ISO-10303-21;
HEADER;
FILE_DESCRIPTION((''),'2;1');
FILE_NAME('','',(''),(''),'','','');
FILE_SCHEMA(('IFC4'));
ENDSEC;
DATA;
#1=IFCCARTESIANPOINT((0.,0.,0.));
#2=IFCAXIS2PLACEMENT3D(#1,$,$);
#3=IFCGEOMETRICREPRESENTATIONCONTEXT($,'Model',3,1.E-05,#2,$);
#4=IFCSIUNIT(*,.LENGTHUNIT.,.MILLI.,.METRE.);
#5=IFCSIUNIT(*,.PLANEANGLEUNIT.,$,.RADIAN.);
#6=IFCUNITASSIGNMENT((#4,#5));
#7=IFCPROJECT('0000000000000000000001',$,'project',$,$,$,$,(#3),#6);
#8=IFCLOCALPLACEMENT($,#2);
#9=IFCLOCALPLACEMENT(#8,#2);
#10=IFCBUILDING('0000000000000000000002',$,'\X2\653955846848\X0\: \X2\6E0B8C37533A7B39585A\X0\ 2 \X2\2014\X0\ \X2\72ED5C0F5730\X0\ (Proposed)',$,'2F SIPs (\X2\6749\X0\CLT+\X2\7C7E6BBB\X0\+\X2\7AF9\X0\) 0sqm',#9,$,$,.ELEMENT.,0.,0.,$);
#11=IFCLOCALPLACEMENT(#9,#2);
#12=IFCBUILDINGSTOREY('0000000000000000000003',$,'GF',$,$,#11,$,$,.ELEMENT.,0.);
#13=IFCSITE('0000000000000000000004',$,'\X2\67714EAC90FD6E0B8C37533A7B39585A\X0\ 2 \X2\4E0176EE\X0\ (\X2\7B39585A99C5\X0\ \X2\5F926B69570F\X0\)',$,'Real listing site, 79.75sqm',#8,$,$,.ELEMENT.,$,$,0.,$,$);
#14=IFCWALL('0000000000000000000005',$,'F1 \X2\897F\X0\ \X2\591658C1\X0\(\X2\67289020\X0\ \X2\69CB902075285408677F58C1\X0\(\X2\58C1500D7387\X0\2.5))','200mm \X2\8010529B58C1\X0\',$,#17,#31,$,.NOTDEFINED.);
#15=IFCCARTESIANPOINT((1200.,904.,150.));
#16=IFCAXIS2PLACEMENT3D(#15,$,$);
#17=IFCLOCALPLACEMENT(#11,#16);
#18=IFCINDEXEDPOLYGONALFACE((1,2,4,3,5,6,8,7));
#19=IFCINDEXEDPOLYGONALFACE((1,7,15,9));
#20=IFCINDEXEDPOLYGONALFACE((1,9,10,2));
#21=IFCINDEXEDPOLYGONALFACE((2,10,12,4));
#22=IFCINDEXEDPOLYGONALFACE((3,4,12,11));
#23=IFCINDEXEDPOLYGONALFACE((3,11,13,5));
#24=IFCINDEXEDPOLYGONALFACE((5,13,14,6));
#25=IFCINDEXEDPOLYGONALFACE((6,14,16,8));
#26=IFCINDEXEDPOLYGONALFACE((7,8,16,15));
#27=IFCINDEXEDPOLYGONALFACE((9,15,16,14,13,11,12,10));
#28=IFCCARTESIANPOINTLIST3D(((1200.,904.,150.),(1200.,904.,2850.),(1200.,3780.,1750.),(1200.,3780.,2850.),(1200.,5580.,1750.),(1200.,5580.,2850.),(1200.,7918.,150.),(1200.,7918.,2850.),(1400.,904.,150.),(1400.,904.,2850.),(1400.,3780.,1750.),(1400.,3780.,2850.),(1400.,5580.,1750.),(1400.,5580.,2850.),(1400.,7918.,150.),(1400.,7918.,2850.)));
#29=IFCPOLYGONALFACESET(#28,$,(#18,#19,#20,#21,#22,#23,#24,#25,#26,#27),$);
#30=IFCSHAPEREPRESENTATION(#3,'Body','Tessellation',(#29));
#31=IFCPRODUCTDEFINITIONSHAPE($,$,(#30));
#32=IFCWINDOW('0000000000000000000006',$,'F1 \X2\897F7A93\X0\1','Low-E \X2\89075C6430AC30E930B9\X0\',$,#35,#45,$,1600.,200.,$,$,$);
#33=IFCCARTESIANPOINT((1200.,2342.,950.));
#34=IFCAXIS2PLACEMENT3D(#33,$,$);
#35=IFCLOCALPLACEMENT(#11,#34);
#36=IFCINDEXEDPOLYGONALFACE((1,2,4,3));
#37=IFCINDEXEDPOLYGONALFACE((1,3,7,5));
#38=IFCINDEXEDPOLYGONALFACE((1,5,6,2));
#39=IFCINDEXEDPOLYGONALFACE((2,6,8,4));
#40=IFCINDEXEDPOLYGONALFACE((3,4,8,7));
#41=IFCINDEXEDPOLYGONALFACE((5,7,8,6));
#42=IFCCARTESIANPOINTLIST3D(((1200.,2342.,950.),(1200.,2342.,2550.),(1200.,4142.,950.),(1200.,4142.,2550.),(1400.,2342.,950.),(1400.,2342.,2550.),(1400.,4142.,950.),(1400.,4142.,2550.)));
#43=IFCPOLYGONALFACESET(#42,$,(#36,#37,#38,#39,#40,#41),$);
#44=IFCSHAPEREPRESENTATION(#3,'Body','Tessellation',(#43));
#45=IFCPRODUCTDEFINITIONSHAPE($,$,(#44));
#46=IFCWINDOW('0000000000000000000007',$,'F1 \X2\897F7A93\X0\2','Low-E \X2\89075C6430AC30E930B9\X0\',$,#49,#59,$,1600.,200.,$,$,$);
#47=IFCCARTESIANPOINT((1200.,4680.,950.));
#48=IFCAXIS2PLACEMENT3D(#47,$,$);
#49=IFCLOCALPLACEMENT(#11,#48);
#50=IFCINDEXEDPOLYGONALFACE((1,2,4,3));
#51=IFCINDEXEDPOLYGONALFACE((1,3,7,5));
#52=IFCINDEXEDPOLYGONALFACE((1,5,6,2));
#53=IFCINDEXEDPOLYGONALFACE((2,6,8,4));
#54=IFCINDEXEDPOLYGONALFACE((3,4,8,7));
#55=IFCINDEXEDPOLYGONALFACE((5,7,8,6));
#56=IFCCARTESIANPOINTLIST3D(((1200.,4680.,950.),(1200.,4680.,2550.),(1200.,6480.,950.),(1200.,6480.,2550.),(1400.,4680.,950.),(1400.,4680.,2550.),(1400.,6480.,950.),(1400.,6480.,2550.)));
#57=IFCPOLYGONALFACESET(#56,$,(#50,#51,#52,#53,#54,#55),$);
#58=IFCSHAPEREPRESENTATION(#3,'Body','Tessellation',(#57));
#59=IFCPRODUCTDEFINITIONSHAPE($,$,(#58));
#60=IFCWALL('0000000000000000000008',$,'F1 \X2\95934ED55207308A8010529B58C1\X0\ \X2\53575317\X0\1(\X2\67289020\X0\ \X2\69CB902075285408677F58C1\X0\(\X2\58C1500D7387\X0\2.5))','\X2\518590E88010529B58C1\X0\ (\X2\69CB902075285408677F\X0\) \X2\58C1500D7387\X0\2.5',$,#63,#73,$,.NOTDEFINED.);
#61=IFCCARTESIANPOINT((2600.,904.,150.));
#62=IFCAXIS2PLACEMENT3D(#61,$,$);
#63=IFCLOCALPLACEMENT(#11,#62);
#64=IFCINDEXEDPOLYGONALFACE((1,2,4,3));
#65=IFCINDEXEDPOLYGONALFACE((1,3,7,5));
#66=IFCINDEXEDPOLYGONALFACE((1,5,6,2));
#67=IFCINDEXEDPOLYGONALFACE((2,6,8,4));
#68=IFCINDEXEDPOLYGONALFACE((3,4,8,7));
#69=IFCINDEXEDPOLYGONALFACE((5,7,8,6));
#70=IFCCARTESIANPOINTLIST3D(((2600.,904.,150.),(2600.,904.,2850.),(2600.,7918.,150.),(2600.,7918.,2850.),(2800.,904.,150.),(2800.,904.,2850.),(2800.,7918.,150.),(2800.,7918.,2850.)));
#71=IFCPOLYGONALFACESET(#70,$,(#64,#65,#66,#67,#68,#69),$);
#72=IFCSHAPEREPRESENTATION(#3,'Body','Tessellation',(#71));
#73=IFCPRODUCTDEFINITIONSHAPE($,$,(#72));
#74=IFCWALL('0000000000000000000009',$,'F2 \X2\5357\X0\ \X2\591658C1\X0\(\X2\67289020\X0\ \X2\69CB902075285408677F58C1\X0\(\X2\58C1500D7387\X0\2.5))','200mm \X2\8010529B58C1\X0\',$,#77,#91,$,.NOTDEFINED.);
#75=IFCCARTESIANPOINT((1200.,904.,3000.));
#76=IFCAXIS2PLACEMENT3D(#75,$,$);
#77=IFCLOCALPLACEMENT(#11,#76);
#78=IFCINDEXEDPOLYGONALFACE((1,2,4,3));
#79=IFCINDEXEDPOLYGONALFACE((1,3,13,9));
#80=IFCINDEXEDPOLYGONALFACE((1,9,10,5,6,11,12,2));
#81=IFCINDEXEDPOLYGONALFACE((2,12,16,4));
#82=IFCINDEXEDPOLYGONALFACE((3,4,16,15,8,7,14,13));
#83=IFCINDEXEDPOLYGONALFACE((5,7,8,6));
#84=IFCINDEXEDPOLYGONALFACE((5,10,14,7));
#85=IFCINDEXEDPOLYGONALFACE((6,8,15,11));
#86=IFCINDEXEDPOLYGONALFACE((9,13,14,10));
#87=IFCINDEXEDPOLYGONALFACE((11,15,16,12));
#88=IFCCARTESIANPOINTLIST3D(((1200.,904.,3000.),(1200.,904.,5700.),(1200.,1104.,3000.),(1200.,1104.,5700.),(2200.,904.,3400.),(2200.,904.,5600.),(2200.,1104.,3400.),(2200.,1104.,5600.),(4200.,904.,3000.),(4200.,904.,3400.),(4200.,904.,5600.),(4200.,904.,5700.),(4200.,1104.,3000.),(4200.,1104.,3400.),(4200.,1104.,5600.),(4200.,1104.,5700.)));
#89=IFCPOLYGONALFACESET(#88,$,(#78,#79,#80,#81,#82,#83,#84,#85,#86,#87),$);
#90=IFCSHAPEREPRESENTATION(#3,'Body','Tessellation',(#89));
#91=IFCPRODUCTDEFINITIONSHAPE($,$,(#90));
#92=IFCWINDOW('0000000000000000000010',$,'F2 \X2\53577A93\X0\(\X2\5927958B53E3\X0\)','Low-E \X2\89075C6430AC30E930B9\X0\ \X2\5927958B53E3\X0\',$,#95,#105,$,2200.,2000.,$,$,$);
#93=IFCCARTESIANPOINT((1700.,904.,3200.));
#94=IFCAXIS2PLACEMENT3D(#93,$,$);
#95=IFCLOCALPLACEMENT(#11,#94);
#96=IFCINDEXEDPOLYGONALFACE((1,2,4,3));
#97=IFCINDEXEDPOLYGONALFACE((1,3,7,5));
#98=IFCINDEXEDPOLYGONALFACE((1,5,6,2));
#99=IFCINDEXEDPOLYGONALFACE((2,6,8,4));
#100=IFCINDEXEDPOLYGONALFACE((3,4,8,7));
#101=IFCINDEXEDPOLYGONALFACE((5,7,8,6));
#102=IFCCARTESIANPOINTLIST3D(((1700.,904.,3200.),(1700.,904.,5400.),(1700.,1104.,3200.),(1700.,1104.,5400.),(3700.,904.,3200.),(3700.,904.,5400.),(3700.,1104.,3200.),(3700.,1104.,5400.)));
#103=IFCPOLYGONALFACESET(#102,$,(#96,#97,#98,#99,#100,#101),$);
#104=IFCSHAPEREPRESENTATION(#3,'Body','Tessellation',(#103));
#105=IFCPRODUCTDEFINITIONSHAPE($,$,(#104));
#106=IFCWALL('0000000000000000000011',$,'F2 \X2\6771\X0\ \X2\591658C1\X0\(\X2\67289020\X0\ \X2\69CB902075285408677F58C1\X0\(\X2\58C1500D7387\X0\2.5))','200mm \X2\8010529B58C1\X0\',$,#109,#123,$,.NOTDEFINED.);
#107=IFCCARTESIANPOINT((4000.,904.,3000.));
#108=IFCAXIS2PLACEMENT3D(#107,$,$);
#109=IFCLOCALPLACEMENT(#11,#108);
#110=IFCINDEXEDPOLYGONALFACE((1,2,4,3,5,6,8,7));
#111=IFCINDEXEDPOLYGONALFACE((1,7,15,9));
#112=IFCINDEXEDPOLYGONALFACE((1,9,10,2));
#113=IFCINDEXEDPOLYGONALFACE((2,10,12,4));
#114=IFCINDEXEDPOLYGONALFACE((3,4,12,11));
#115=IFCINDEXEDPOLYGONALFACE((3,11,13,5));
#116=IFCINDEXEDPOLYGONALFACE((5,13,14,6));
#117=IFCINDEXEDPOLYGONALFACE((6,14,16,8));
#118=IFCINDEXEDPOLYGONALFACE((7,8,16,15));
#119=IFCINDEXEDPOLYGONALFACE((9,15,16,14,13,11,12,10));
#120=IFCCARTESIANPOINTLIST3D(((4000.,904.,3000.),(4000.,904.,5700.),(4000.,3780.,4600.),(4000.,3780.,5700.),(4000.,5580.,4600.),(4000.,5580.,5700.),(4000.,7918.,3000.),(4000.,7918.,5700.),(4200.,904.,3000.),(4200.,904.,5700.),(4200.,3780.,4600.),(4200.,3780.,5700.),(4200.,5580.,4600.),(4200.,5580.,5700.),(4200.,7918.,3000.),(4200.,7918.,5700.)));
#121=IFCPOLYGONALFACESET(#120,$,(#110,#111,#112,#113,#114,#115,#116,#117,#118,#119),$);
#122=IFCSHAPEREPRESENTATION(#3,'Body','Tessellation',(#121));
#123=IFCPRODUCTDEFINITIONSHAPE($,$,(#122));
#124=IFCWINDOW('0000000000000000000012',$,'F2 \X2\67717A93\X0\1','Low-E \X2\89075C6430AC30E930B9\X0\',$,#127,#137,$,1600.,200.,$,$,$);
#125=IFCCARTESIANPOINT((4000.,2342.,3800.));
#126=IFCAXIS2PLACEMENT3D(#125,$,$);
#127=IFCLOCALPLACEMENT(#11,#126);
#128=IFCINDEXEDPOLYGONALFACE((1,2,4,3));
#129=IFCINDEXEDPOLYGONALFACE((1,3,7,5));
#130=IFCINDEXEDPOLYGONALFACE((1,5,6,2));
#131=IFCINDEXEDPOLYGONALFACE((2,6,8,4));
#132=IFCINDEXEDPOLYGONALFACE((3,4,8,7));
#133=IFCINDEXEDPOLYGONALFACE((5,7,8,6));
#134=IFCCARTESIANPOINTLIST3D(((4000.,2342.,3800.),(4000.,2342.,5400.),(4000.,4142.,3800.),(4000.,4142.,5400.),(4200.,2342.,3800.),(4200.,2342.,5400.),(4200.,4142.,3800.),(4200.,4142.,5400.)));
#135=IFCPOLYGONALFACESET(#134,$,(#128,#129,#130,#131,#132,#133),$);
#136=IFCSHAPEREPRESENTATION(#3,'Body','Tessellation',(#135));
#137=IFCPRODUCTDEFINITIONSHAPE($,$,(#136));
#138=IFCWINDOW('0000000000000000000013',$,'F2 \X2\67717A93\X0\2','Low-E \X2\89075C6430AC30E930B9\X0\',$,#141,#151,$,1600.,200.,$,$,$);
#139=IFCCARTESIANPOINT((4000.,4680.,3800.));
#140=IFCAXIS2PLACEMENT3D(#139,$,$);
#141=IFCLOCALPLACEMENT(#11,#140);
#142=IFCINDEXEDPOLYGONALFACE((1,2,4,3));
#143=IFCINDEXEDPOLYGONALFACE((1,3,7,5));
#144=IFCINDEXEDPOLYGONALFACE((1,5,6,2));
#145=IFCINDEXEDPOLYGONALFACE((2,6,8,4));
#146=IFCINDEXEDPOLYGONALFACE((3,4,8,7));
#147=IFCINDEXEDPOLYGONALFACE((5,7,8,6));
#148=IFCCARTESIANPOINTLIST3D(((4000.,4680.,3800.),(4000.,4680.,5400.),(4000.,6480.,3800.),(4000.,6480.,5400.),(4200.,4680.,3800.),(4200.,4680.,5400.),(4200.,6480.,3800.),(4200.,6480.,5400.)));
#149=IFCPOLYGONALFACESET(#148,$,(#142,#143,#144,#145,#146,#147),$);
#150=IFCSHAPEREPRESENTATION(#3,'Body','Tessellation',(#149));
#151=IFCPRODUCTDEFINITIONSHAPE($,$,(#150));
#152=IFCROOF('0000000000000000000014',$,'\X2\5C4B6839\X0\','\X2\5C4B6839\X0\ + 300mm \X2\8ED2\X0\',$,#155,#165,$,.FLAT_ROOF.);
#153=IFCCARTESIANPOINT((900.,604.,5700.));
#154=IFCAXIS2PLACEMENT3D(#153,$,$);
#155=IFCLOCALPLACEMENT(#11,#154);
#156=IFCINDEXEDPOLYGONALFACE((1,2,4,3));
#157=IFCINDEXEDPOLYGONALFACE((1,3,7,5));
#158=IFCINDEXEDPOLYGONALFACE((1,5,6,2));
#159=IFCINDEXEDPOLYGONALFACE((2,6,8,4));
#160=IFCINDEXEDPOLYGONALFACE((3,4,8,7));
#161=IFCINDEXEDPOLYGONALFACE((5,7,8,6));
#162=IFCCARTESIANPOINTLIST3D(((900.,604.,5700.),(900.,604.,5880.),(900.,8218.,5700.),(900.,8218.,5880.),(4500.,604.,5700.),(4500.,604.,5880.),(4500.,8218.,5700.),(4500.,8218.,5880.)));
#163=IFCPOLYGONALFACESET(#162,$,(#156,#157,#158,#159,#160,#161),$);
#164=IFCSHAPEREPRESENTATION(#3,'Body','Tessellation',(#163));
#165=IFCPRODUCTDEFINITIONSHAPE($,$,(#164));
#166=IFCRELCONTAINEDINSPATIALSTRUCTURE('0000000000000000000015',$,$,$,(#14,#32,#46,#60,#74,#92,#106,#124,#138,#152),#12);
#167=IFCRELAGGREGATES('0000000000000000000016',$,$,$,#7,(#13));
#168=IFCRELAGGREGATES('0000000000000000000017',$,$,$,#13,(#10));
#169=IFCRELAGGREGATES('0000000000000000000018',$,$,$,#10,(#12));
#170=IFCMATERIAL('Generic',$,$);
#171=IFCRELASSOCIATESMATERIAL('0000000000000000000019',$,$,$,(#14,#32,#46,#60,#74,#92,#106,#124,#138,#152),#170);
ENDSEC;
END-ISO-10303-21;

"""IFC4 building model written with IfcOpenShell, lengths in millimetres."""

from ifc_helpers import new_model, si_unit, frame, frame_2d, origin, place, context, project, spatial, rectangle, extrude, material, element, fill, save


model = new_model("IFC4")

# Units and contexts
model_context = context("Model", 3, precision=1e-05, world=origin())
ifc_project = project(units=[si_unit("LENGTHUNIT", "METRE", prefix="MILLI"), si_unit("PLANEANGLEUNIT", "RADIAN")], contexts=[model_context])

# Site, building, storey
site_placement = place(None, origin())
site = spatial("IfcSite", under=ifc_project, at=site_placement, Name="東京都渋谷区笹塚 2 丁目 (笹塚駅 徒歩圏)", ObjectType="Real listing site, 79.75sqm", CompositionType="ELEMENT", RefElevation=0.0)
building_placement = place(site_placement, origin())
building = spatial("IfcBuilding", under=site, at=building_placement, Name="改善案: 渋谷区笹塚 2 — 狭小地 (Proposed)", ObjectType="2F SIPs (杉CLT+籾殻+竹) 0sqm", CompositionType="ELEMENT", ElevationOfRefHeight=0.0, ElevationOfTerrain=0.0)
storey_placement = place(building_placement, origin())
storey = spatial("IfcBuildingStorey", under=building, at=storey_placement, Name="GF", CompositionType="ELEMENT", Elevation=0.0)

# Shared definitions
ifc_material_1 = material(Name="Generic")

# Wall, openings, windows
wall_1_placement = place(storey_placement, frame((1200.0, 904.0, 150.0)))
wall_1 = element("IfcWall", 1, at=wall_1_placement, inside=storey, material=ifc_material_1, Name="F1 西 外壁(木造 構造用合板壁(壁倍率2.5))", Description="200mm 耐力壁", PredefinedType="NOTDEFINED", context=model_context, shape_type="SweptSolid", body=[
    extrude(rectangle(XDim=200.0, YDim=7014.0, at=frame_2d((100.0, 3507.0))), frame((1200.0, 904.0, 150.0)), (0.0, 0.0, 1.0), 2700.0),
])
opening_1_placement = place(storey_placement, frame((1200.0, 2342.0, 950.0)))
opening_1 = element("IfcOpeningElement", 2, at=opening_1_placement, cuts=wall_1, PredefinedType="NOTDEFINED", context=model_context, shape_type="SweptSolid", body=[
    extrude(rectangle(XDim=200.0, YDim=1800.0, at=frame_2d((100.0, 900.0))), frame((1200.0, 2342.0, 950.0)), (0.0, 0.0, 1.0), 1600.0),
])
opening_2_placement = place(storey_placement, frame((1200.0, 4680.0, 950.0)))
opening_2 = element("IfcOpeningElement", 3, at=opening_2_placement, cuts=wall_1, PredefinedType="NOTDEFINED", context=model_context, shape_type="SweptSolid", body=[
    extrude(rectangle(XDim=200.0, YDim=1800.0, at=frame_2d((100.0, 900.0))), frame((1200.0, 4680.0, 950.0)), (0.0, 0.0, 1.0), 1600.0),
])
window_1_placement = place(storey_placement, frame((1200.0, 2342.0, 950.0)))
window_1 = element("IfcWindow", 4, at=window_1_placement, inside=storey, material=ifc_material_1, Name="F1 西窓1", Description="Low-E 複層ガラス", OverallHeight=1600.0, OverallWidth=200.0, context=model_context, shape_type="SweptSolid", body=[
    extrude(rectangle(XDim=200.0, YDim=1800.0, at=frame_2d((100.0, 900.0))), frame((1200.0, 2342.0, 950.0)), (0.0, 0.0, 1.0), 1600.0),
])
fill(opening_1, window_1)
window_2_placement = place(storey_placement, frame((1200.0, 4680.0, 950.0)))
window_2 = element("IfcWindow", 5, at=window_2_placement, inside=storey, material=ifc_material_1, Name="F1 西窓2", Description="Low-E 複層ガラス", OverallHeight=1600.0, OverallWidth=200.0, context=model_context, shape_type="SweptSolid", body=[
    extrude(rectangle(XDim=200.0, YDim=1800.0, at=frame_2d((100.0, 900.0))), frame((1200.0, 4680.0, 950.0)), (0.0, 0.0, 1.0), 1600.0),
])
fill(opening_2, window_2)

# Wall
wall_2_placement = place(storey_placement, frame((2600.0, 904.0, 150.0)))
element("IfcWall", 6, at=wall_2_placement, inside=storey, material=ifc_material_1, Name="F1 間仕切り耐力壁 南北1(木造 構造用合板壁(壁倍率2.5))", Description="内部耐力壁 (構造用合板) 壁倍率2.5", PredefinedType="NOTDEFINED", context=model_context, shape_type="SweptSolid", body=[
    extrude(rectangle(XDim=200.0, YDim=7014.0, at=frame_2d((100.0, 3507.0))), frame((2600.0, 904.0, 150.0)), (0.0, 0.0, 1.0), 2700.0),
])

# Wall, opening, window
wall_3_placement = place(storey_placement, frame((1200.0, 904.0, 3000.0)))
wall_3 = element("IfcWall", 7, at=wall_3_placement, inside=storey, material=ifc_material_1, Name="F2 南 外壁(木造 構造用合板壁(壁倍率2.5))", Description="200mm 耐力壁", PredefinedType="NOTDEFINED", context=model_context, shape_type="SweptSolid", body=[
    extrude(rectangle(XDim=3000.0, YDim=200.0, at=frame_2d((1500.0, 100.0))), frame((1200.0, 904.0, 3000.0)), (0.0, 0.0, 1.0), 2700.0),
])
opening_3_placement = place(storey_placement, frame((1700.0, 904.0, 3200.0)))
opening_3 = element("IfcOpeningElement", 8, at=opening_3_placement, cuts=wall_3, PredefinedType="NOTDEFINED", context=model_context, shape_type="SweptSolid", body=[
    extrude(rectangle(XDim=2000.0, YDim=200.0, at=frame_2d((1000.0, 100.0))), frame((1700.0, 904.0, 3200.0)), (0.0, 0.0, 1.0), 2200.0),
])
window_3_placement = place(storey_placement, frame((1700.0, 904.0, 3200.0)))
window_3 = element("IfcWindow", 9, at=window_3_placement, inside=storey, material=ifc_material_1, Name="F2 南窓(大開口)", Description="Low-E 複層ガラス 大開口", OverallHeight=2200.0, OverallWidth=2000.0, context=model_context, shape_type="SweptSolid", body=[
    extrude(rectangle(XDim=2000.0, YDim=200.0, at=frame_2d((1000.0, 100.0))), frame((1700.0, 904.0, 3200.0)), (0.0, 0.0, 1.0), 2200.0),
])
fill(opening_3, window_3)

# Wall, openings, windows
wall_4_placement = place(storey_placement, frame((4000.0, 904.0, 3000.0)))
wall_4 = element("IfcWall", 10, at=wall_4_placement, inside=storey, material=ifc_material_1, Name="F2 東 外壁(木造 構造用合板壁(壁倍率2.5))", Description="200mm 耐力壁", PredefinedType="NOTDEFINED", context=model_context, shape_type="SweptSolid", body=[
    extrude(rectangle(XDim=200.0, YDim=7014.0, at=frame_2d((100.0, 3507.0))), frame((4000.0, 904.0, 3000.0)), (0.0, 0.0, 1.0), 2700.0),
])
opening_4_placement = place(storey_placement, frame((4000.0, 2342.0, 3800.0)))
opening_4 = element("IfcOpeningElement", 11, at=opening_4_placement, cuts=wall_4, PredefinedType="NOTDEFINED", context=model_context, shape_type="SweptSolid", body=[
    extrude(rectangle(XDim=200.0, YDim=1800.0, at=frame_2d((100.0, 900.0))), frame((4000.0, 2342.0, 3800.0)), (0.0, 0.0, 1.0), 1600.0),
])
opening_5_placement = place(storey_placement, frame((4000.0, 4680.0, 3800.0)))
opening_5 = element("IfcOpeningElement", 12, at=opening_5_placement, cuts=wall_4, PredefinedType="NOTDEFINED", context=model_context, shape_type="SweptSolid", body=[
    extrude(rectangle(XDim=200.0, YDim=1800.0, at=frame_2d((100.0, 900.0))), frame((4000.0, 4680.0, 3800.0)), (0.0, 0.0, 1.0), 1600.0),
])
window_4_placement = place(storey_placement, frame((4000.0, 2342.0, 3800.0)))
window_4 = element("IfcWindow", 13, at=window_4_placement, inside=storey, material=ifc_material_1, Name="F2 東窓1", Description="Low-E 複層ガラス", OverallHeight=1600.0, OverallWidth=200.0, context=model_context, shape_type="SweptSolid", body=[
    extrude(rectangle(XDim=200.0, YDim=1800.0, at=frame_2d((100.0, 900.0))), frame((4000.0, 2342.0, 3800.0)), (0.0, 0.0, 1.0), 1600.0),
])
fill(opening_4, window_4)
window_5_placement = place(storey_placement, frame((4000.0, 4680.0, 3800.0)))
window_5 = element("IfcWindow", 14, at=window_5_placement, inside=storey, material=ifc_material_1, Name="F2 東窓2", Description="Low-E 複層ガラス", OverallHeight=1600.0, OverallWidth=200.0, context=model_context, shape_type="SweptSolid", body=[
    extrude(rectangle(XDim=200.0, YDim=1800.0, at=frame_2d((100.0, 900.0))), frame((4000.0, 4680.0, 3800.0)), (0.0, 0.0, 1.0), 1600.0),
])
fill(opening_5, window_5)

# Roof
roof_placement = place(storey_placement, frame((900.0, 604.0, 5700.0)))
element("IfcRoof", 15, at=roof_placement, inside=storey, material=ifc_material_1, Name="屋根", Description="屋根 + 300mm 軒", PredefinedType="FLAT_ROOF", context=model_context, shape_type="SweptSolid", body=[
    extrude(rectangle(XDim=3600.0, YDim=7614.0, at=frame_2d((1800.0, 3807.0))), frame((900.0, 604.0, 5700.0)), (0.0, 0.0, 1.0), 180.0),
])

save(model, "model.ifc")
